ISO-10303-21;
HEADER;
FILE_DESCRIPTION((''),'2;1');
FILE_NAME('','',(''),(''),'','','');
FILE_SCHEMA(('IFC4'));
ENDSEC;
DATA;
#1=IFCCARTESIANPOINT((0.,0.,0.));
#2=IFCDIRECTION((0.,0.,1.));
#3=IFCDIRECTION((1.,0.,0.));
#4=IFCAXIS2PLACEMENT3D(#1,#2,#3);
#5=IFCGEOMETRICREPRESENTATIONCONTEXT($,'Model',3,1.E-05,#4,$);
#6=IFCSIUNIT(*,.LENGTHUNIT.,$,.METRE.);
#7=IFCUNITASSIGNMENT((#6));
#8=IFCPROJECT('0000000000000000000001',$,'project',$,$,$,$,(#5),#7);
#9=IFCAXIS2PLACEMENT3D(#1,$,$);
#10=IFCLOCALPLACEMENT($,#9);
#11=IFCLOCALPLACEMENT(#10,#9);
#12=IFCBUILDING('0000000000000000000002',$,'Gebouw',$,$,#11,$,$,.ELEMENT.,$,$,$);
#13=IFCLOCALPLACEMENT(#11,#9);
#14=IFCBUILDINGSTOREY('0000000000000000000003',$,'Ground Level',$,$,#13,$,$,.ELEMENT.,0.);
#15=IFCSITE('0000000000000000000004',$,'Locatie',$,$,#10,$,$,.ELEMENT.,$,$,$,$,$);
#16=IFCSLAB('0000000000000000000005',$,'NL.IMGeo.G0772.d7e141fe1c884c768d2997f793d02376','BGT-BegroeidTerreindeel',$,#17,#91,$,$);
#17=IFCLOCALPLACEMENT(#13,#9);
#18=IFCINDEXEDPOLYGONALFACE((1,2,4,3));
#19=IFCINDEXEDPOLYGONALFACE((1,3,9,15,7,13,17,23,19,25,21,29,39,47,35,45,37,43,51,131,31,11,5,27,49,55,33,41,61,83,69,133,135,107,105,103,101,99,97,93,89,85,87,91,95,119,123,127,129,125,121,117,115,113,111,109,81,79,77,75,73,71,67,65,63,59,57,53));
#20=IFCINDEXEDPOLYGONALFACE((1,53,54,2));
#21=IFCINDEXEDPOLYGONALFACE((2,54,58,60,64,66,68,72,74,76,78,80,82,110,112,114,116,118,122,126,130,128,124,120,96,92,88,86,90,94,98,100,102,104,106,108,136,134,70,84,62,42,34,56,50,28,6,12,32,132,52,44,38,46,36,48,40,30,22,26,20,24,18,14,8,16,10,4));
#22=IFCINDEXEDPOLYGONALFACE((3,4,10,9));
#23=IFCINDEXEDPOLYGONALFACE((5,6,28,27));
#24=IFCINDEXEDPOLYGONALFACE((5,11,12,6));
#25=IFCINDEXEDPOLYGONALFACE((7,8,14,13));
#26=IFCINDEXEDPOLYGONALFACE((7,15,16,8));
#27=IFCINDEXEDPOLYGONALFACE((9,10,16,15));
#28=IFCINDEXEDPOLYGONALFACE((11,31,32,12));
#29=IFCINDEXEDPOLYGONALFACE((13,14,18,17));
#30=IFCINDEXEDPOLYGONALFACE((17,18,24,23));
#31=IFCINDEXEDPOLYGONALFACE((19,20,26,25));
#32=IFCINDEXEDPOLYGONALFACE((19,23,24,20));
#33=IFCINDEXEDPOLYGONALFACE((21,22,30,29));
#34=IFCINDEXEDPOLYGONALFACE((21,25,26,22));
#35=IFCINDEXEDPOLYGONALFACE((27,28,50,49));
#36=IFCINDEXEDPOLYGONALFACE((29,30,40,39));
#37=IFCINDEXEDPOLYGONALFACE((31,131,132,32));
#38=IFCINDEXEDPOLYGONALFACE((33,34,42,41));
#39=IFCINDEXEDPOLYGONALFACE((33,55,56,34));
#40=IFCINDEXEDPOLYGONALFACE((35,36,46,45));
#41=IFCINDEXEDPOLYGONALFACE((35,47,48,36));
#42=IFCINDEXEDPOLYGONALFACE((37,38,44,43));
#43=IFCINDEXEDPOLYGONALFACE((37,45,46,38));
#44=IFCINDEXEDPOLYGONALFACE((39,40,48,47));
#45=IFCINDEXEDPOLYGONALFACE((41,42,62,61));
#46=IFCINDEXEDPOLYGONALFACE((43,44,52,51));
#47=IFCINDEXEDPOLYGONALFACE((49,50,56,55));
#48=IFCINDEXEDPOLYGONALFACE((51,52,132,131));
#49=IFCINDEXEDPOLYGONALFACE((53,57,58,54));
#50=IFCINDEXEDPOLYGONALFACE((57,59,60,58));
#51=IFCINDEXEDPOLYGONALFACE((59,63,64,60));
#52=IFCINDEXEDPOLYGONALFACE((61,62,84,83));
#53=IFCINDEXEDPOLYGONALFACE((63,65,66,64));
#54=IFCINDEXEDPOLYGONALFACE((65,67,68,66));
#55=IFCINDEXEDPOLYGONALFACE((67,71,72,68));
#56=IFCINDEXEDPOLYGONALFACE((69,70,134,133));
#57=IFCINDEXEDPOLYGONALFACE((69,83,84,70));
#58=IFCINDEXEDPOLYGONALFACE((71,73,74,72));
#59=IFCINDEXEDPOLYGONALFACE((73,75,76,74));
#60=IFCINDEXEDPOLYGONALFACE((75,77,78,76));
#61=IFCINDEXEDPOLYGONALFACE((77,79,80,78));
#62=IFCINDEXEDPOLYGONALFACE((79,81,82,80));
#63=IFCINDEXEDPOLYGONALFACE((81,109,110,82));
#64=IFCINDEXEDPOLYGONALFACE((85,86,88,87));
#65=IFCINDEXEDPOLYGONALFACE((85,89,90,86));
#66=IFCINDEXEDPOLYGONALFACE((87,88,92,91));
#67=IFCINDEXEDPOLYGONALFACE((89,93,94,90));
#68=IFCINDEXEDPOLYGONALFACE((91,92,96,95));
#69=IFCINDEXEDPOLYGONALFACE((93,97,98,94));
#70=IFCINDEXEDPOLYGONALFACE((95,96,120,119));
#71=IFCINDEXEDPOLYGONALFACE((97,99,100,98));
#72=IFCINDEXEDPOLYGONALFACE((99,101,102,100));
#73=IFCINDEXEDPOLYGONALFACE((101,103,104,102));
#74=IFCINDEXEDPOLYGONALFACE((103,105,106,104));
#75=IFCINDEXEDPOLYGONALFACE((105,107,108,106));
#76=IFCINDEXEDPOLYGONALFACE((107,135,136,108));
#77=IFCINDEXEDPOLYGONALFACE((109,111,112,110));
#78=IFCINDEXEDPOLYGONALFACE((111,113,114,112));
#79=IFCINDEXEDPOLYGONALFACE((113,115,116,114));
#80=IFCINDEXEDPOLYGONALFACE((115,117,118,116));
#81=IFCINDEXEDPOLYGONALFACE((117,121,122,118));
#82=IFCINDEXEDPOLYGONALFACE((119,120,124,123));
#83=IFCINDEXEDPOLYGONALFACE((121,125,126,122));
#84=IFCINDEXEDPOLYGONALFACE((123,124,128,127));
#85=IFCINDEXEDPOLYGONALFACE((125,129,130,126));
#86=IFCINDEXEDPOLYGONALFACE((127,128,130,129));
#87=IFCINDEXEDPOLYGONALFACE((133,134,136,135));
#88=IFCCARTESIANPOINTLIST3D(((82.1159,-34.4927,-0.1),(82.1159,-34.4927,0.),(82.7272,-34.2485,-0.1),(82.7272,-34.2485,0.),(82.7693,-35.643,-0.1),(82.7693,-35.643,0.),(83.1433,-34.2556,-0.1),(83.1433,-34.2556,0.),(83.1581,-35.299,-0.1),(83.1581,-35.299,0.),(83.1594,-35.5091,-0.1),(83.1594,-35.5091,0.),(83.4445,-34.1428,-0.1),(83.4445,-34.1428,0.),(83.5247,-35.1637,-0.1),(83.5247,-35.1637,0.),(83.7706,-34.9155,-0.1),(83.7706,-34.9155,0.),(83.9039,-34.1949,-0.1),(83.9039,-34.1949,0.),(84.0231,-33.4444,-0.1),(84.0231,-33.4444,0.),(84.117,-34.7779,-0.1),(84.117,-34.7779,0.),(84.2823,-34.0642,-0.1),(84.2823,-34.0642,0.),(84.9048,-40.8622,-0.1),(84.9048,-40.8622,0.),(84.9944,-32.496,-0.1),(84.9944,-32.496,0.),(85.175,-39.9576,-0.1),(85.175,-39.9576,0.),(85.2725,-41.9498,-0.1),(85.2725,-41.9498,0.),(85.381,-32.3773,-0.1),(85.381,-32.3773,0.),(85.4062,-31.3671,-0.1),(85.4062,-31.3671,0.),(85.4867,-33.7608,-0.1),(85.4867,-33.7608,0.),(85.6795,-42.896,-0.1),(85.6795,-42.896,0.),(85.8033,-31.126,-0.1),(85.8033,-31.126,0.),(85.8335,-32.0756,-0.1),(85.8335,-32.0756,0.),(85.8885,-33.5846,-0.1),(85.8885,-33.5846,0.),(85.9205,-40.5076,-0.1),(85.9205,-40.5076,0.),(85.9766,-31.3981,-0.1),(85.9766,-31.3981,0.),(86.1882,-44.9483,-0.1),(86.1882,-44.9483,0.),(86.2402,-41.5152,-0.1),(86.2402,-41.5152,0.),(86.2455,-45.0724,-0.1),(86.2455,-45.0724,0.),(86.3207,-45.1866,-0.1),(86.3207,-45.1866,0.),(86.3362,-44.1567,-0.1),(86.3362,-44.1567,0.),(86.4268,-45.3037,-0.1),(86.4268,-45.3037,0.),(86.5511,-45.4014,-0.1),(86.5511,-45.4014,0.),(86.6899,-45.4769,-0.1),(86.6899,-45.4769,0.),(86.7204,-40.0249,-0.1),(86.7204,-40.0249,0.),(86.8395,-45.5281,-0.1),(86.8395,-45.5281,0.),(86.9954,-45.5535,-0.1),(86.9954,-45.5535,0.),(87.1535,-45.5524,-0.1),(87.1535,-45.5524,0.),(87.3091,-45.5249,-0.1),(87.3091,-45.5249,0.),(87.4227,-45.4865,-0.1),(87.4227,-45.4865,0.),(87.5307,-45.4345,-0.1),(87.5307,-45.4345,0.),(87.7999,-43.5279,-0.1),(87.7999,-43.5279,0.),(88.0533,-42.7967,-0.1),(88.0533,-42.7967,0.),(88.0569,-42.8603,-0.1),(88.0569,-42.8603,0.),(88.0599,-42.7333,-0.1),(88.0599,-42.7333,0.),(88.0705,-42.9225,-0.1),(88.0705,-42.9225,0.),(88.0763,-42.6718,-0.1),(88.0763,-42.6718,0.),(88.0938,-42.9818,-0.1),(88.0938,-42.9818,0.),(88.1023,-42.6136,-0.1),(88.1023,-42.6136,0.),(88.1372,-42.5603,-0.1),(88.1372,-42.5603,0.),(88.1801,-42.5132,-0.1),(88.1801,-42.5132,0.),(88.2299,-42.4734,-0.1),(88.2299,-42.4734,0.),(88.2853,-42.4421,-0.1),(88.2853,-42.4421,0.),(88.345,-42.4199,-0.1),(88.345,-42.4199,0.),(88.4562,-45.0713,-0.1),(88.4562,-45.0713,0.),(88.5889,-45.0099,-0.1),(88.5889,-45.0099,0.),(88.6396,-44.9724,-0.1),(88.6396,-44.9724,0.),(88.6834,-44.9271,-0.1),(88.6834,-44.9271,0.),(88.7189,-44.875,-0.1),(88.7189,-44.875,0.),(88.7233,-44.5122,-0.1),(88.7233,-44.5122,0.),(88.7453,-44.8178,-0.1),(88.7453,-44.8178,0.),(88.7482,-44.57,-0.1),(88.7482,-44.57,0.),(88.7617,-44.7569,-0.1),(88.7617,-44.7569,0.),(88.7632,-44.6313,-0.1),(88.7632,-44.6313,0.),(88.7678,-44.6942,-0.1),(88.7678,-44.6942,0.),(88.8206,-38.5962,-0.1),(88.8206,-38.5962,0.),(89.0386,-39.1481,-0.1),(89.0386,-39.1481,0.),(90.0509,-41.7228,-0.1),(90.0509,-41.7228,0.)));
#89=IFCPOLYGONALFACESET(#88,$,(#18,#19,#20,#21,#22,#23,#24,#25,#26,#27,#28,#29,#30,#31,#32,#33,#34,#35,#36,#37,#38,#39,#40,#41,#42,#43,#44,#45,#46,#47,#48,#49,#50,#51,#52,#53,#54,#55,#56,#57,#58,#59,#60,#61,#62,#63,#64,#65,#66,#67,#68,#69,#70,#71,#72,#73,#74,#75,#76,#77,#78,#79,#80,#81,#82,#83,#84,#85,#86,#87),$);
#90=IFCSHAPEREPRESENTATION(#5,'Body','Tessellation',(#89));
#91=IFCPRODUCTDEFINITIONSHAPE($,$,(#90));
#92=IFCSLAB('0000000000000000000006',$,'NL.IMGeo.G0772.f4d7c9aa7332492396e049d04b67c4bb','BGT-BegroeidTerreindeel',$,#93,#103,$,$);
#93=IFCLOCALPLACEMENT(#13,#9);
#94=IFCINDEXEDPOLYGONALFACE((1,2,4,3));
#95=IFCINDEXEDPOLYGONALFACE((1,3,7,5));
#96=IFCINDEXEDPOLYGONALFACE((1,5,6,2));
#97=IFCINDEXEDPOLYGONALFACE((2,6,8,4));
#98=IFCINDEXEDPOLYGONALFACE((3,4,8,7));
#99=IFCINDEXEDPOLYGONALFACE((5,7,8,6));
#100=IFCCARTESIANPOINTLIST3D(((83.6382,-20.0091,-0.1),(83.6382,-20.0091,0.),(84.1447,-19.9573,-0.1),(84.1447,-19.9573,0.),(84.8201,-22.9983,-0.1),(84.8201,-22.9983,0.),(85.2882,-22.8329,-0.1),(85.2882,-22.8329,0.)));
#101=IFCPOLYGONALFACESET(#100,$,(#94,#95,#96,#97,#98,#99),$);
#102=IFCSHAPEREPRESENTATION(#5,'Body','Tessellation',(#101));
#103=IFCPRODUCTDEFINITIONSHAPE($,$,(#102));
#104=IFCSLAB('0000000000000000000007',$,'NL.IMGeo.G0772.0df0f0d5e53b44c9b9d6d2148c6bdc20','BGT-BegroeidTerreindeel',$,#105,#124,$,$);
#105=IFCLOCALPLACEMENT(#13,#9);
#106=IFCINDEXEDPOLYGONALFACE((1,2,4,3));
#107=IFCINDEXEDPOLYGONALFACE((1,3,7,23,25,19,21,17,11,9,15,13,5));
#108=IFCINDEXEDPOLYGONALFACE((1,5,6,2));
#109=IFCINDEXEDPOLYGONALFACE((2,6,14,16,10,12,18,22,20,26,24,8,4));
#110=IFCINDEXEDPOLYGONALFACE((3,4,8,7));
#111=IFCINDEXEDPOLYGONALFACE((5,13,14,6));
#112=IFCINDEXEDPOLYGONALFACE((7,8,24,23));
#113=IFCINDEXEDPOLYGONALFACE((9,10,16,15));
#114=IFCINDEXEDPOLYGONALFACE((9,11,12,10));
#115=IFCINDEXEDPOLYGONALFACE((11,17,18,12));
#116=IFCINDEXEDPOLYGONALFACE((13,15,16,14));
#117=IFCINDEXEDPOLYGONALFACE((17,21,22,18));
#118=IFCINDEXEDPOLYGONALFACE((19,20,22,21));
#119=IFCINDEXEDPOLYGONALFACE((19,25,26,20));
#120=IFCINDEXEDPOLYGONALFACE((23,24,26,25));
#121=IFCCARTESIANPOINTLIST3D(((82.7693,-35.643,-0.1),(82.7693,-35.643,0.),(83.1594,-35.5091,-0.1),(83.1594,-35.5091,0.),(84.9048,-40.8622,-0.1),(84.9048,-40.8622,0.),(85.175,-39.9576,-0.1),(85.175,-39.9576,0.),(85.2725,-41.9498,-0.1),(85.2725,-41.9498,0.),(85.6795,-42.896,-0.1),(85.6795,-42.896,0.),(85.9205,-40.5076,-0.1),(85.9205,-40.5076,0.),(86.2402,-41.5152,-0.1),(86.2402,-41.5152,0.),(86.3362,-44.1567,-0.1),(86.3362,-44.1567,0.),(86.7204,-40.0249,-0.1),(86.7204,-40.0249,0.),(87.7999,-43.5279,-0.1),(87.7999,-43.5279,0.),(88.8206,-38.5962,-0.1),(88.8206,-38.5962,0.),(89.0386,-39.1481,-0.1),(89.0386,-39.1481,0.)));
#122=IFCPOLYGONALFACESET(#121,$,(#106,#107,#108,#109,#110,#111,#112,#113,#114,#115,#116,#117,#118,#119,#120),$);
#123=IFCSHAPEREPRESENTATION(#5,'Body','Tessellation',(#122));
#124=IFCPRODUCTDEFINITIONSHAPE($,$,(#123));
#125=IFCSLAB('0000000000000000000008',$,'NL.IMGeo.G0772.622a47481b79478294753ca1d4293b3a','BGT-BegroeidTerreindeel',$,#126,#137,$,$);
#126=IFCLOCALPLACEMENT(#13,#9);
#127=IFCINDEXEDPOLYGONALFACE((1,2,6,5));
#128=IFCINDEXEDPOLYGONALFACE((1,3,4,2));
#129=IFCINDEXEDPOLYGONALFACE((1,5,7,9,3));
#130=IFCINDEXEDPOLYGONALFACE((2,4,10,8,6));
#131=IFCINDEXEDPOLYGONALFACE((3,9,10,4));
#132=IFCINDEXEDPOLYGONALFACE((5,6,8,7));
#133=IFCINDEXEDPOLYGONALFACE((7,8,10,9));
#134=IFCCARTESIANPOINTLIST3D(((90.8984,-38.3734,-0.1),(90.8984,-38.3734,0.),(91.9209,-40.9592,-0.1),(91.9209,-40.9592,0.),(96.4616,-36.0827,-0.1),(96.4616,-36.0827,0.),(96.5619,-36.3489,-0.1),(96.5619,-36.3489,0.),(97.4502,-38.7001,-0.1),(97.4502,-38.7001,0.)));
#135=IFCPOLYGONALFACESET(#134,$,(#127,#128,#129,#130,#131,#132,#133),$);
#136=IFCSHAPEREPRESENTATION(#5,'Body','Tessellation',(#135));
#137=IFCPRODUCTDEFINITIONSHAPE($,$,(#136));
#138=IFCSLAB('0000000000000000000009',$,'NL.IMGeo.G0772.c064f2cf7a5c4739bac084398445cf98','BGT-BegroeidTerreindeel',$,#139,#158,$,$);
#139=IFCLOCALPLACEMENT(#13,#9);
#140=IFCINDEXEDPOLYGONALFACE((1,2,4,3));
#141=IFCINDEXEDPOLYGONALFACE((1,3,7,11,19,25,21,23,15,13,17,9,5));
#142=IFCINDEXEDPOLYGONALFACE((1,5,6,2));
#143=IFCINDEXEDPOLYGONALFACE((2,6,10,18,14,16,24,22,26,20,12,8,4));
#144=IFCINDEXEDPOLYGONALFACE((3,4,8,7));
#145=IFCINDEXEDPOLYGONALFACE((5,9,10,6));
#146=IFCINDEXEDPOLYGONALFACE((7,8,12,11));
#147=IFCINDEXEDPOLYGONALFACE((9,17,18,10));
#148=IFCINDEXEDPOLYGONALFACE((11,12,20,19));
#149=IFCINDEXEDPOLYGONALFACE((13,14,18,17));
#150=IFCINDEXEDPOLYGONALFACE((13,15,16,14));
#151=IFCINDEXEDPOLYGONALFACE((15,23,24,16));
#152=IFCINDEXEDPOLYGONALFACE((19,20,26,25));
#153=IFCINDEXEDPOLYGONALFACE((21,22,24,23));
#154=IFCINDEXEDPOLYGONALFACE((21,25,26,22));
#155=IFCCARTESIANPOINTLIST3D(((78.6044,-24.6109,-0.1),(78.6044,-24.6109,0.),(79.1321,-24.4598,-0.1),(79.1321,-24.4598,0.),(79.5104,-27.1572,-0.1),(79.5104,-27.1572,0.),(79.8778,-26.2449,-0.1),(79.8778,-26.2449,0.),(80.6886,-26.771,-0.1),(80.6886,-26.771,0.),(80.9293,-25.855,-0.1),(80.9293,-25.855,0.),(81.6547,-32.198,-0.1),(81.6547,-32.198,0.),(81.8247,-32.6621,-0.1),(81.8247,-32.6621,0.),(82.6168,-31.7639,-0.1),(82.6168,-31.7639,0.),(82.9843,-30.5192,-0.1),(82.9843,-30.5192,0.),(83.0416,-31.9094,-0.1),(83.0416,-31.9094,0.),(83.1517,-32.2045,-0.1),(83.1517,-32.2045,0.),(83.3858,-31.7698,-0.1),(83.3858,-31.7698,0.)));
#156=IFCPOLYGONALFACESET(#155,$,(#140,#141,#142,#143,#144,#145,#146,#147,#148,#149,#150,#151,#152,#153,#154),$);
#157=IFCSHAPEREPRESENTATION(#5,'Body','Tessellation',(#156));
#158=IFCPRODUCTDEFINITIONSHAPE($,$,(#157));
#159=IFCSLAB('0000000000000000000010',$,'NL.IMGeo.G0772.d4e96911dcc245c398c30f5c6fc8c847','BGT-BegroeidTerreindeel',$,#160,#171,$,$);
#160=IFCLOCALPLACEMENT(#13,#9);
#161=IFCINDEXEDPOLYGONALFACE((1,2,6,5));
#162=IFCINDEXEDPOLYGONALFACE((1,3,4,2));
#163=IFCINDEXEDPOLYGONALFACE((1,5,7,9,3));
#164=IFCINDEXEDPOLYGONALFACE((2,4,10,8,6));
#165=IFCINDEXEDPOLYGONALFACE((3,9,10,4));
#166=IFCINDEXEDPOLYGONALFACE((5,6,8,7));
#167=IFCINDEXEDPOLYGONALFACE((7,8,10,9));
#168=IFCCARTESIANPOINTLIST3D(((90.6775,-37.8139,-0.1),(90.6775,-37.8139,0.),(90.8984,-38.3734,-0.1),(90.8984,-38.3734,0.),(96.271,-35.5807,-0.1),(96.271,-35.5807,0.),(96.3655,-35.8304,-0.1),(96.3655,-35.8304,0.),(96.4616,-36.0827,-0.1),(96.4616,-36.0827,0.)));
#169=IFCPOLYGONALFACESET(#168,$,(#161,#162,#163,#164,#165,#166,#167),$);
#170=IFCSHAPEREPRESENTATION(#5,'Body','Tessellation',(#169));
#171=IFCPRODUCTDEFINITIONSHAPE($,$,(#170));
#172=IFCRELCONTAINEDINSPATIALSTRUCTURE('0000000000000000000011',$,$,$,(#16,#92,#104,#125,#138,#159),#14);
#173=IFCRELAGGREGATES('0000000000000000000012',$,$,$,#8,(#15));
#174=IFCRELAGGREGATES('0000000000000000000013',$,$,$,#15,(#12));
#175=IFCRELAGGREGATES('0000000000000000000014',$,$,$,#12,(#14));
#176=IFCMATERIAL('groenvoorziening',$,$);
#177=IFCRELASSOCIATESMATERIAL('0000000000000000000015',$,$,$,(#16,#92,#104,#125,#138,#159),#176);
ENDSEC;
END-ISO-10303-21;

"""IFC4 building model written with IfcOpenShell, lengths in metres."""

from ifc_helpers import new_model, si_unit, frame, origin, origin_with_axes, place, context, project, spatial, polyline, outline, extrude, material, element, save


model = new_model("IFC4")

# Units and contexts
model_context = context("Model", 3, precision=1e-05, world=origin_with_axes())
ifc_project = project(units=[si_unit("LENGTHUNIT", "METRE")], contexts=[model_context])

# Site, building, storey
site_placement = place(None, origin())
site = spatial("IfcSite", under=ifc_project, at=site_placement, Name="Locatie", CompositionType="ELEMENT")
building_placement = place(site_placement, origin())
building = spatial("IfcBuilding", under=site, at=building_placement, Name="Gebouw", CompositionType="ELEMENT")
storey_placement = place(building_placement, origin())
storey = spatial("IfcBuildingStorey", under=building, at=storey_placement, Name="Ground Level", CompositionType="ELEMENT", Elevation=0.0)

# Slabs
ifc_material = material(Name="groenvoorziening")
slab_1_placement = place(storey_placement, origin())
element("IfcSlab", 1, at=slab_1_placement, inside=storey, material=ifc_material, Name="NL.IMGeo.G0772.d7e141fe1c884c768d2997f793d02376", Description="BGT-BegroeidTerreindeel", context=model_context, shape_type="SweptSolid", body=[
    extrude(outline(polyline([(88.8206, -38.5962), (85.175, -39.9576), (83.1594, -35.5091), (82.7693, -35.643), (84.9048, -40.8622), (85.9205, -40.5076), (86.2402, -41.5152), (85.2725, -41.9498), (85.6795, -42.896), (86.3362, -44.1567), (87.7999, -43.5279), (86.7204, -40.0249), (89.0386, -39.1481), (90.0509, -41.7228), (88.345, -42.4199), (88.2853, -42.4421), (88.2299, -42.4734), (88.1801, -42.5132), (88.1372, -42.5603), (88.1023, -42.6136), (88.0763, -42.6718), (88.0599, -42.7333), (88.0533, -42.7967), (88.0569, -42.8603), (88.0705, -42.9225), (88.0938, -42.9818), (88.7233, -44.5122), (88.7482, -44.57), (88.7632, -44.6313), (88.7678, -44.6942), (88.7617, -44.7569), (88.7453, -44.8178), (88.7189, -44.875), (88.6834, -44.9271), (88.6396, -44.9724), (88.5889, -45.0099), (88.4562, -45.0713), (87.5307, -45.4345), (87.4227, -45.4865), (87.3091, -45.5249), (87.1535, -45.5524), (86.9954, -45.5535), (86.8395, -45.5281), (86.6899, -45.4769), (86.5511, -45.4014), (86.4268, -45.3037), (86.3207, -45.1866), (86.2455, -45.0724), (86.1882, -44.9483), (82.1159, -34.4927), (82.7272, -34.2485), (83.1581, -35.299), (83.5247, -35.1637), (83.1433, -34.2556), (83.4445, -34.1428), (83.7706, -34.9155), (84.117, -34.7779), (83.9039, -34.1949), (84.2823, -34.0642), (84.0231, -33.4444), (84.9944, -32.496), (85.4867, -33.7608), (85.8885, -33.5846), (85.381, -32.3773), (85.8335, -32.0756), (85.4062, -31.3671), (85.8033, -31.126), (85.9766, -31.3981), (88.8206, -38.5962)])), frame((0.0, 0.0, -0.1), z_axis=(0.0, 0.0, 1.0), x_axis=(1.0, 0.0, 0.0)), (0.0, 0.0, 1.0), 0.1),
])
slab_2_placement = place(storey_placement, origin())
element("IfcSlab", 2, at=slab_2_placement, inside=storey, material=ifc_material, Name="NL.IMGeo.G0772.f4d7c9aa7332492396e049d04b67c4bb", Description="BGT-BegroeidTerreindeel", context=model_context, shape_type="SweptSolid", body=[
    extrude(outline(polyline([(85.2882, -22.8329), (84.8201, -22.9983), (83.6382, -20.0091), (84.1447, -19.9573), (85.2882, -22.8329)])), frame((0.0, 0.0, -0.1), z_axis=(0.0, 0.0, 1.0), x_axis=(1.0, 0.0, 0.0)), (0.0, 0.0, 1.0), 0.1),
])
slab_3_placement = place(storey_placement, origin())
element("IfcSlab", 3, at=slab_3_placement, inside=storey, material=ifc_material, Name="NL.IMGeo.G0772.0df0f0d5e53b44c9b9d6d2148c6bdc20", Description="BGT-BegroeidTerreindeel", context=model_context, shape_type="SweptSolid", body=[
    extrude(outline(polyline([(86.7204, -40.0249), (87.7999, -43.5279), (86.3362, -44.1567), (85.6795, -42.896), (85.2725, -41.9498), (86.2402, -41.5152), (85.9205, -40.5076), (84.9048, -40.8622), (82.7693, -35.643), (83.1594, -35.5091), (85.175, -39.9576), (88.8206, -38.5962), (89.0386, -39.1481), (86.7204, -40.0249)])), frame((0.0, 0.0, -0.1), z_axis=(0.0, 0.0, 1.0), x_axis=(1.0, 0.0, 0.0)), (0.0, 0.0, 1.0), 0.1),
])
slab_4_placement = place(storey_placement, origin())
element("IfcSlab", 4, at=slab_4_placement, inside=storey, material=ifc_material, Name="NL.IMGeo.G0772.622a47481b79478294753ca1d4293b3a", Description="BGT-BegroeidTerreindeel", context=model_context, shape_type="SweptSolid", body=[
    extrude(outline(polyline([(96.5619, -36.3489), (97.4502, -38.7001), (91.9209, -40.9592), (90.8984, -38.3734), (96.4616, -36.0827), (96.5619, -36.3489)])), frame((0.0, 0.0, -0.1), z_axis=(0.0, 0.0, 1.0), x_axis=(1.0, 0.0, 0.0)), (0.0, 0.0, 1.0), 0.1),
])
slab_5_placement = place(storey_placement, origin())
element("IfcSlab", 5, at=slab_5_placement, inside=storey, material=ifc_material, Name="NL.IMGeo.G0772.c064f2cf7a5c4739bac084398445cf98", Description="BGT-BegroeidTerreindeel", context=model_context, shape_type="SweptSolid", body=[
    extrude(outline(polyline([(79.1321, -24.4598), (79.8778, -26.2449), (80.9293, -25.855), (82.9843, -30.5192), (83.3858, -31.7698), (83.0416, -31.9094), (83.1517, -32.2045), (81.8247, -32.6621), (81.6547, -32.198), (82.6168, -31.7639), (80.6886, -26.771), (79.5104, -27.1572), (78.6044, -24.6109), (79.1321, -24.4598)])), frame((0.0, 0.0, -0.1), z_axis=(0.0, 0.0, 1.0), x_axis=(1.0, 0.0, 0.0)), (0.0, 0.0, 1.0), 0.1),
])
slab_6_placement = place(storey_placement, origin())
element("IfcSlab", 6, at=slab_6_placement, inside=storey, material=ifc_material, Name="NL.IMGeo.G0772.d4e96911dcc245c398c30f5c6fc8c847", Description="BGT-BegroeidTerreindeel", context=model_context, shape_type="SweptSolid", body=[
    extrude(outline(polyline([(96.271, -35.5807), (96.3655, -35.8304), (96.4616, -36.0827), (90.8984, -38.3734), (90.6775, -37.8139), (96.271, -35.5807)])), frame((0.0, 0.0, -0.1), z_axis=(0.0, 0.0, 1.0), x_axis=(1.0, 0.0, 0.0)), (0.0, 0.0, 1.0), 0.1),
])

save(model, "model.ifc")
